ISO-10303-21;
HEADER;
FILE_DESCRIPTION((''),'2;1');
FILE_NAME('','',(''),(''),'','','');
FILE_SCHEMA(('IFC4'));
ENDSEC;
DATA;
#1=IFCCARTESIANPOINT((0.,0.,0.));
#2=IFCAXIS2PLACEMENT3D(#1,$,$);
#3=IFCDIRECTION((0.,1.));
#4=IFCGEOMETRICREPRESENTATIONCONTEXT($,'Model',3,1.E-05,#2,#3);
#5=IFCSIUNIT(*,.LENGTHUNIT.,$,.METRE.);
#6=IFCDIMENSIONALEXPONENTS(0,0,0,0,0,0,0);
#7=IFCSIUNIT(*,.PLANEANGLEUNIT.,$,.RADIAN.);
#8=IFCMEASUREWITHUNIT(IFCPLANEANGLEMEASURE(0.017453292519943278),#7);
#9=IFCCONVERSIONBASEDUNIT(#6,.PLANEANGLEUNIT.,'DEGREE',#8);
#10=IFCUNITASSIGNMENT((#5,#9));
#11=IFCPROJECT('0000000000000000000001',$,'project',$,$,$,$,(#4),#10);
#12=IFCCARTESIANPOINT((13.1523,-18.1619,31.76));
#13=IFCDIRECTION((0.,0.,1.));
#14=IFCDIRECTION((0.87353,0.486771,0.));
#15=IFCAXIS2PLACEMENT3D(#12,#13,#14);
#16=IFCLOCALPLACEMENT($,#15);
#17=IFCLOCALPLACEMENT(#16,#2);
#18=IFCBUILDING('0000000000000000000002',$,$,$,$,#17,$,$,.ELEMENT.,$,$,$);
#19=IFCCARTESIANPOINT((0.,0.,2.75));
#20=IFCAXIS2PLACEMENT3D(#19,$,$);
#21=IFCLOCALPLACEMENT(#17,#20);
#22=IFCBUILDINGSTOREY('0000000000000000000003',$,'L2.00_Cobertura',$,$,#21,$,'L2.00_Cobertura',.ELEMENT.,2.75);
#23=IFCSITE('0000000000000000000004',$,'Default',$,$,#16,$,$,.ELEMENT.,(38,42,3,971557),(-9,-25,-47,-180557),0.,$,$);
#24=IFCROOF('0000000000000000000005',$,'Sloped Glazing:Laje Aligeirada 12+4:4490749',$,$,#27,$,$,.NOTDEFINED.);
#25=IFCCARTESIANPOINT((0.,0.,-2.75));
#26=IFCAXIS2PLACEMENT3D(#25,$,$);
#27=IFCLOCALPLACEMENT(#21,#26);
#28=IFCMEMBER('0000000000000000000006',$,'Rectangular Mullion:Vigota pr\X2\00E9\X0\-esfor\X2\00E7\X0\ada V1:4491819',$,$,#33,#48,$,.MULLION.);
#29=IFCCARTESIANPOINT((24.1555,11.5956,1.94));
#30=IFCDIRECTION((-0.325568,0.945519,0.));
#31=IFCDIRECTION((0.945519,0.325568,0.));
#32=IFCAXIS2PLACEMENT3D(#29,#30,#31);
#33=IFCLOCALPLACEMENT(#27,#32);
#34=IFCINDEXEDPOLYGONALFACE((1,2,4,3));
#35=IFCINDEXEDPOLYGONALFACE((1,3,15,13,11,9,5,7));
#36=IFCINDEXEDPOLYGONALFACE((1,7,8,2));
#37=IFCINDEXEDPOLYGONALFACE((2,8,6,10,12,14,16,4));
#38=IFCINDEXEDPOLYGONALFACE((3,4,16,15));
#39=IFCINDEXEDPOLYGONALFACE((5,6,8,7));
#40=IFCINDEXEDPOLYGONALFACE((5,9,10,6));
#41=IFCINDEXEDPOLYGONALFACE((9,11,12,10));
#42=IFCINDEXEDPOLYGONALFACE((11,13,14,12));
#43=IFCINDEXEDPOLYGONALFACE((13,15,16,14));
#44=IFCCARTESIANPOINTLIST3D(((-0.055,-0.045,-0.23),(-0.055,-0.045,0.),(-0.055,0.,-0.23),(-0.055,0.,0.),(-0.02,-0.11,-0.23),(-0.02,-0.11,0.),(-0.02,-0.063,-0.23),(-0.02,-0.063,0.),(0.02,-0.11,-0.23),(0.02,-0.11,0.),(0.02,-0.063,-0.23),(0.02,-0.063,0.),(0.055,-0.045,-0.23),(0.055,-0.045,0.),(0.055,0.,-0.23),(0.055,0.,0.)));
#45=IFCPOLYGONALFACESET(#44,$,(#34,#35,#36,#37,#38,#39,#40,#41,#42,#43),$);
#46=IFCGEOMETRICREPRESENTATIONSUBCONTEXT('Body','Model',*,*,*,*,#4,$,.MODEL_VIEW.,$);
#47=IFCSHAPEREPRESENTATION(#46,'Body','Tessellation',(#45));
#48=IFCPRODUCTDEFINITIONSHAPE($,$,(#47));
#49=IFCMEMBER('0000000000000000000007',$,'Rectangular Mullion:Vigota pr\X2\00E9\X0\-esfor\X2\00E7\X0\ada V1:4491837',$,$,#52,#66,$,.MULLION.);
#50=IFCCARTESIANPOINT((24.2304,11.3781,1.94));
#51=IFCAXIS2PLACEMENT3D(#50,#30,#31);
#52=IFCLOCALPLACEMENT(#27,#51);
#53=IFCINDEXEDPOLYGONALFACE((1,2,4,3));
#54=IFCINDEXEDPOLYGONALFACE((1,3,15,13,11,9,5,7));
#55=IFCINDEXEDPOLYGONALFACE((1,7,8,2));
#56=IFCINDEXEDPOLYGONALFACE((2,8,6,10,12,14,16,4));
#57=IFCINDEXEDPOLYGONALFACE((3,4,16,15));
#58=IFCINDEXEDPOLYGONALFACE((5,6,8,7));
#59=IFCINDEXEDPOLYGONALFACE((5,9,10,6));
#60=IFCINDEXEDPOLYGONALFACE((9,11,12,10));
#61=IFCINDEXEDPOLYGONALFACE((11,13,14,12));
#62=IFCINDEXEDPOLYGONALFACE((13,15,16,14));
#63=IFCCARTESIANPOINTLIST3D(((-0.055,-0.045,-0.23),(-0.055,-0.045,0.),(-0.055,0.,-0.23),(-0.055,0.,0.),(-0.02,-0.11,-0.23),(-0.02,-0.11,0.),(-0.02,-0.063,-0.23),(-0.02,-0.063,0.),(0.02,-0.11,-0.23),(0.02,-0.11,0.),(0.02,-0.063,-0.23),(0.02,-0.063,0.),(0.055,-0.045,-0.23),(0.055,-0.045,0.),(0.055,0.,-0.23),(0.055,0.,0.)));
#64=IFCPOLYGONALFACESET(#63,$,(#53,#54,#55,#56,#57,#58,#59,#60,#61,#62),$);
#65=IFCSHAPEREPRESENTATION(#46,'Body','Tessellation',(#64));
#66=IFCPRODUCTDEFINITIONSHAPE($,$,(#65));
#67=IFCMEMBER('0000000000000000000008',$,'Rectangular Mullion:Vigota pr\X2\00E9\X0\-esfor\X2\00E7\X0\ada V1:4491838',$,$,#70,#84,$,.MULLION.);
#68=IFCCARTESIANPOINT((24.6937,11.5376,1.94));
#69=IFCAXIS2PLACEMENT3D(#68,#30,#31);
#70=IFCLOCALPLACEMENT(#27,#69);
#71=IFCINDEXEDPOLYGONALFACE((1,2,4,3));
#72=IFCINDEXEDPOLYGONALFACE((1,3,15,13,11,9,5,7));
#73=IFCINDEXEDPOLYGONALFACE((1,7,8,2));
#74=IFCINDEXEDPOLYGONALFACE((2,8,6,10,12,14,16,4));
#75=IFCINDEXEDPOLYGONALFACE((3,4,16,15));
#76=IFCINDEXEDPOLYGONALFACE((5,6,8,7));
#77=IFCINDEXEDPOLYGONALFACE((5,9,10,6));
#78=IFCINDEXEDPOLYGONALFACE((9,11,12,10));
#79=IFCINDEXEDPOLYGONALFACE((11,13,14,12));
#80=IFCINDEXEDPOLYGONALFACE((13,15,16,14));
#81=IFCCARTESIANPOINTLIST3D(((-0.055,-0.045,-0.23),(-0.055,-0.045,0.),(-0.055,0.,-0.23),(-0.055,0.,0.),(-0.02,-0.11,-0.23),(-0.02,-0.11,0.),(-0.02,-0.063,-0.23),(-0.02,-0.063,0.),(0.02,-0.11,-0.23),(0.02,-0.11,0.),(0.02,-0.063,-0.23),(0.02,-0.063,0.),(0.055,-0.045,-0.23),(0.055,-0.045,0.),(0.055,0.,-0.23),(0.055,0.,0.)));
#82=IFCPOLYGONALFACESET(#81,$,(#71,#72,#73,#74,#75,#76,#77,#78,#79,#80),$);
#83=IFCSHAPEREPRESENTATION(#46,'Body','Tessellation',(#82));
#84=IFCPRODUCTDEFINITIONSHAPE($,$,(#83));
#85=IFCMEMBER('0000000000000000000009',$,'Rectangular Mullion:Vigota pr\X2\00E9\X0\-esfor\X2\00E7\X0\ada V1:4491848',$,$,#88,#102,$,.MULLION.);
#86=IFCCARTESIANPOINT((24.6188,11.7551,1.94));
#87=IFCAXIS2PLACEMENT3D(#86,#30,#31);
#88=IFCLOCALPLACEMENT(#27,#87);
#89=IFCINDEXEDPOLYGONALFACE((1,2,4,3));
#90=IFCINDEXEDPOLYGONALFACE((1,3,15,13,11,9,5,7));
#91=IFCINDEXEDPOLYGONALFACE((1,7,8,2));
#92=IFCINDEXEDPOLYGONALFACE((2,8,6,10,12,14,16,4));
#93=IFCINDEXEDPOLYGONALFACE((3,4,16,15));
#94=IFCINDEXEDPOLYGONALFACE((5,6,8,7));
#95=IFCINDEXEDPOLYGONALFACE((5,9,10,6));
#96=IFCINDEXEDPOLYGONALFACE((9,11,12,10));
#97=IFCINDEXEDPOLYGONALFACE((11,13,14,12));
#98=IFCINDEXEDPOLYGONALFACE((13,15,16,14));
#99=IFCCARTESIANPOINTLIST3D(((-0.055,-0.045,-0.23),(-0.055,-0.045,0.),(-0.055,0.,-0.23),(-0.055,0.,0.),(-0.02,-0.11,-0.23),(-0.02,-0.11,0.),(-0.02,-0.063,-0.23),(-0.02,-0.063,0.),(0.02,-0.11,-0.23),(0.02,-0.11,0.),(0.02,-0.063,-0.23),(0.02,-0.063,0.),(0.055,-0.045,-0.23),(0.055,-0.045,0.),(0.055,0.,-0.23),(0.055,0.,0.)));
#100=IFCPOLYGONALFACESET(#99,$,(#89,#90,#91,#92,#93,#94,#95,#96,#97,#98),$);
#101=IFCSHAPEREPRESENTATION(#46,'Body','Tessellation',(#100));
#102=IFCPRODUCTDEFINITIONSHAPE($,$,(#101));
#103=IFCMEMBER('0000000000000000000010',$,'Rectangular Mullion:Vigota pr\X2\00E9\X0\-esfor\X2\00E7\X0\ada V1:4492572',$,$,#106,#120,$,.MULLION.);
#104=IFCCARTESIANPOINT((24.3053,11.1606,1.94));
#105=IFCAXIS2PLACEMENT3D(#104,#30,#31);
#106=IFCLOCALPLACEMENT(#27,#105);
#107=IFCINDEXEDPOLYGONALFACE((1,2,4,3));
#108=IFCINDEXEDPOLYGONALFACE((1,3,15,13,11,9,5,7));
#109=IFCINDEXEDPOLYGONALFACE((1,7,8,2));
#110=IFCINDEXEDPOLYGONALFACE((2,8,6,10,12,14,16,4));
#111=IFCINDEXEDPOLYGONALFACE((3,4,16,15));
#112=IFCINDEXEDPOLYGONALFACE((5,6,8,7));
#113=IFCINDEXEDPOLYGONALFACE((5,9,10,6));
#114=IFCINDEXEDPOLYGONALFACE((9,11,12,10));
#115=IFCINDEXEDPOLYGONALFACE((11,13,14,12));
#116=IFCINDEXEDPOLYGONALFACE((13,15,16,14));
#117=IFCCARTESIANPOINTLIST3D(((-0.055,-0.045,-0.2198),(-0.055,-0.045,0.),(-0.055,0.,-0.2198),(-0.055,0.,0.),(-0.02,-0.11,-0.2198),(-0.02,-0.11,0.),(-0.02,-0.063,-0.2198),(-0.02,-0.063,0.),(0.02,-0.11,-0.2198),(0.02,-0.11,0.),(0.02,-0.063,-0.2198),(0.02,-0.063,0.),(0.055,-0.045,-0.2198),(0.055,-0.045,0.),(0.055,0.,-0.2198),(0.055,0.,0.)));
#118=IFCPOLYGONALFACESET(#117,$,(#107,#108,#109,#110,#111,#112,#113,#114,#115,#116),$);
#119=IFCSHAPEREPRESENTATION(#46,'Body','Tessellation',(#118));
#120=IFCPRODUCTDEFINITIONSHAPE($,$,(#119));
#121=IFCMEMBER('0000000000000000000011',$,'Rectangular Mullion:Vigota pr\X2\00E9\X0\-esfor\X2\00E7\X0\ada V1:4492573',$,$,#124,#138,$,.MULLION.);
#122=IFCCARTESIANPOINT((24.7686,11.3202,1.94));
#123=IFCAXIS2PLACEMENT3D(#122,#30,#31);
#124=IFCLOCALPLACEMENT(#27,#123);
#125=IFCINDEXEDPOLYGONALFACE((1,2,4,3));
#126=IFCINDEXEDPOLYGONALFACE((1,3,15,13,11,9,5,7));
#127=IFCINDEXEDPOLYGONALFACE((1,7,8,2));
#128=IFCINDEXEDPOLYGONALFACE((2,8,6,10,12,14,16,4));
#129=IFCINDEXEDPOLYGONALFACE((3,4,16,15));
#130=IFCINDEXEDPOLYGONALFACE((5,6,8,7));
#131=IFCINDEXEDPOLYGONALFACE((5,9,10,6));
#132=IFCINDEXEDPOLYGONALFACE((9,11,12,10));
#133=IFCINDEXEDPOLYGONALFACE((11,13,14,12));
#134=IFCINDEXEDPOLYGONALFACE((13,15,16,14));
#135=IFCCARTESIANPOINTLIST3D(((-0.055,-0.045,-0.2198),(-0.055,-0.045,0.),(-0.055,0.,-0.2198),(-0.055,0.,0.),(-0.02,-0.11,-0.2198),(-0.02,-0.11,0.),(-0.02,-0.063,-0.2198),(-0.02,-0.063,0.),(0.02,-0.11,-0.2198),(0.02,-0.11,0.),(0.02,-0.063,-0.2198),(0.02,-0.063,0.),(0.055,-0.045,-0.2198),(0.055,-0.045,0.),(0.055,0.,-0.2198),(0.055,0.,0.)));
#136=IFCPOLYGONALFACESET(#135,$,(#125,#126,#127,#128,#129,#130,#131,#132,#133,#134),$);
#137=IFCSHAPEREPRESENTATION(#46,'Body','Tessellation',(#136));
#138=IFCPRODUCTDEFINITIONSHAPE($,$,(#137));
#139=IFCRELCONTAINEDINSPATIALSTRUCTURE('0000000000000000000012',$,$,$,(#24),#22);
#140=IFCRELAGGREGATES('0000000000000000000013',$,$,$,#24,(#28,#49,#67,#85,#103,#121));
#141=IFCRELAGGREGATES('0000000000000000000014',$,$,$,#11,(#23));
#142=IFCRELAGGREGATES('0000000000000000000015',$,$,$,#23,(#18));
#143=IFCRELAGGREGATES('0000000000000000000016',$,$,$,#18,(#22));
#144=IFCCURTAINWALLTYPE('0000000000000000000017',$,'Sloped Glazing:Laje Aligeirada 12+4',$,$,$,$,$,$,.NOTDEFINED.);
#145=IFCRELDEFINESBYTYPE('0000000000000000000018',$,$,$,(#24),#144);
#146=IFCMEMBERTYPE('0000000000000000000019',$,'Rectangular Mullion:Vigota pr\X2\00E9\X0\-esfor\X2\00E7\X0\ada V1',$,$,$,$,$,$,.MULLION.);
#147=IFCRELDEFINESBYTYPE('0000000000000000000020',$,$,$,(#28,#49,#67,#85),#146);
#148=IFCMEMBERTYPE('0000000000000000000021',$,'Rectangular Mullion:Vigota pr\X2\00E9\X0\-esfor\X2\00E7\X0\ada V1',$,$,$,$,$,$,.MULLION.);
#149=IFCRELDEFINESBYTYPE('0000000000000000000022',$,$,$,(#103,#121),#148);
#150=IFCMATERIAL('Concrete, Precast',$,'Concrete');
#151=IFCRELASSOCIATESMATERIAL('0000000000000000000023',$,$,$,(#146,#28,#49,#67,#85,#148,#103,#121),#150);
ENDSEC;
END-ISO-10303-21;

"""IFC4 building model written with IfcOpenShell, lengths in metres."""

from ifc_helpers import new_model, entity, si_unit, converted_unit, direction, frame, origin, place, context, subcontext, project, spatial, indexed_curve, outline, extrude, source, transform, mapped, material, type_object, type_shapes, element, aggregate, save


model = new_model("IFC4")

# Units and contexts
model_context = context("Model", 3, precision=1e-05, world=origin(), true_north=direction((0.0, 1.0)))
body_context = subcontext(model_context, "Body", "Model", "MODEL_VIEW")
ifc_project = project(units=[si_unit("LENGTHUNIT", "METRE"), converted_unit("PLANEANGLEUNIT", "DEGREE", entity("IfcPlaneAngleMeasure", 0.017453292519943278), si_unit("PLANEANGLEUNIT", "RADIAN"), dimensions=[0, 0, 0, 0, 0, 0, 0])], contexts=[model_context])

# Site, building, storey
site_placement = place(None, frame((13.1523, -18.1619, 31.76), z_axis=(0.0, 0.0, 1.0), x_axis=(0.87353, 0.486771, 0.0)))
site = spatial("IfcSite", under=ifc_project, at=site_placement, Name="Default", CompositionType="ELEMENT", RefLatitude=(38, 42, 3, 971557), RefLongitude=(-9, -25, -47, -180557), RefElevation=0.0)
building_placement = place(site_placement, origin())
building = spatial("IfcBuilding", under=site, at=building_placement, CompositionType="ELEMENT")
storey_placement = place(building_placement, frame((0.0, 0.0, 2.75)))
storey = spatial("IfcBuildingStorey", under=building, at=storey_placement, Name="L2.00_Cobertura", LongName="L2.00_Cobertura", CompositionType="ELEMENT", Elevation=2.75)

# Roof, members
curtain_wall_type = type_object("IfcCurtainWallType", Name="Sloped Glazing:Laje Aligeirada 12+4", PredefinedType="NOTDEFINED")
roof_placement = place(storey_placement, frame((0.0, 0.0, -2.75)))
roof = element("IfcRoof", 1, at=roof_placement, inside=storey, type_object=curtain_wall_type, Name="Sloped Glazing:Laje Aligeirada 12+4:4490749", PredefinedType="NOTDEFINED")
ifc_material_1 = material(Name="Concrete, Precast", Category="Concrete")
member_type_1 = type_object("IfcMemberType", Name="Rectangular Mullion:Vigota pré-esforçada V1", PredefinedType="MULLION", material=ifc_material_1)
shared_shape_1 = source(origin(), body_context, "Body", "SweptSolid", [
    extrude(outline(indexed_curve([(-0.055, -0.0545), (0.055, -0.0545), (0.055, -0.0095), (0.02, 0.0085), (0.02, 0.0555), (-0.02, 0.0555), (-0.02, 0.0085), (-0.055, -0.0095), (-0.055, -0.0545)], self_intersect=False)), frame((0.0, -0.0545, -0.23), z_axis=(0.0, 0.0, 1.0), x_axis=(-1.0, 0.0, 0.0)), (0.0, 0.0, 1.0), 0.23),
])
type_shapes(member_type_1, [shared_shape_1])
member_1_placement = place(roof_placement, frame((24.1555, 11.5956, 1.94), z_axis=(-0.325568, 0.945519, 0.0), x_axis=(0.945519, 0.325568, 0.0)))
member_1 = element("IfcMember", 2, at=member_1_placement, type_object=member_type_1, material=ifc_material_1, Name="Rectangular Mullion:Vigota pré-esforçada V1:4491819", PredefinedType="MULLION", context=body_context, shape_type="MappedRepresentation", body=[
    mapped(shared_shape_1, transform((0.0, 0.0, 0.0), scale=1.0)),
])
member_2_placement = place(roof_placement, frame((24.2304, 11.3781, 1.94), z_axis=(-0.325568, 0.945519, 0.0), x_axis=(0.945519, 0.325568, 0.0)))
member_2 = element("IfcMember", 3, at=member_2_placement, type_object=member_type_1, material=ifc_material_1, Name="Rectangular Mullion:Vigota pré-esforçada V1:4491837", PredefinedType="MULLION", context=body_context, shape_type="MappedRepresentation", body=[
    mapped(shared_shape_1, transform((0.0, 0.0, 0.0), scale=1.0)),
])
member_3_placement = place(roof_placement, frame((24.6937, 11.5376, 1.94), z_axis=(-0.325568, 0.945519, 0.0), x_axis=(0.945519, 0.325568, 0.0)))
member_3 = element("IfcMember", 4, at=member_3_placement, type_object=member_type_1, material=ifc_material_1, Name="Rectangular Mullion:Vigota pré-esforçada V1:4491838", PredefinedType="MULLION", context=body_context, shape_type="MappedRepresentation", body=[
    mapped(shared_shape_1, transform((0.0, 0.0, 0.0), scale=1.0)),
])
member_4_placement = place(roof_placement, frame((24.6188, 11.7551, 1.94), z_axis=(-0.325568, 0.945519, 0.0), x_axis=(0.945519, 0.325568, 0.0)))
member_4 = element("IfcMember", 5, at=member_4_placement, type_object=member_type_1, material=ifc_material_1, Name="Rectangular Mullion:Vigota pré-esforçada V1:4491848", PredefinedType="MULLION", context=body_context, shape_type="MappedRepresentation", body=[
    mapped(shared_shape_1, transform((0.0, 0.0, 0.0), scale=1.0)),
])
member_type_2 = type_object("IfcMemberType", Name="Rectangular Mullion:Vigota pré-esforçada V1", PredefinedType="MULLION", material=ifc_material_1)
shared_shape_2 = source(origin(), body_context, "Body", "SweptSolid", [
    extrude(outline(indexed_curve([(-0.055, -0.0545), (0.055, -0.0545), (0.055, -0.0095), (0.02, 0.0085), (0.02, 0.0555), (-0.02, 0.0555), (-0.02, 0.0085), (-0.055, -0.0095), (-0.055, -0.0545)], self_intersect=False)), frame((0.0, -0.0545, -0.2198), z_axis=(0.0, 0.0, 1.0), x_axis=(-1.0, 0.0, 0.0)), (0.0, 0.0, 1.0), 0.2198),
])
type_shapes(member_type_2, [shared_shape_2])
member_5_placement = place(roof_placement, frame((24.3053, 11.1606, 1.94), z_axis=(-0.325568, 0.945519, 0.0), x_axis=(0.945519, 0.325568, 0.0)))
member_5 = element("IfcMember", 6, at=member_5_placement, type_object=member_type_2, material=ifc_material_1, Name="Rectangular Mullion:Vigota pré-esforçada V1:4492572", PredefinedType="MULLION", context=body_context, shape_type="MappedRepresentation", body=[
    mapped(shared_shape_2, transform((0.0, 0.0, 0.0), scale=1.0)),
])
member_6_placement = place(roof_placement, frame((24.7686, 11.3202, 1.94), z_axis=(-0.325568, 0.945519, 0.0), x_axis=(0.945519, 0.325568, 0.0)))
member_6 = element("IfcMember", 7, at=member_6_placement, type_object=member_type_2, material=ifc_material_1, Name="Rectangular Mullion:Vigota pré-esforçada V1:4492573", PredefinedType="MULLION", context=body_context, shape_type="MappedRepresentation", body=[
    mapped(shared_shape_2, transform((0.0, 0.0, 0.0), scale=1.0)),
])
aggregate(roof, [member_1, member_2, member_3, member_4, member_5, member_6])

save(model, "model.ifc")
